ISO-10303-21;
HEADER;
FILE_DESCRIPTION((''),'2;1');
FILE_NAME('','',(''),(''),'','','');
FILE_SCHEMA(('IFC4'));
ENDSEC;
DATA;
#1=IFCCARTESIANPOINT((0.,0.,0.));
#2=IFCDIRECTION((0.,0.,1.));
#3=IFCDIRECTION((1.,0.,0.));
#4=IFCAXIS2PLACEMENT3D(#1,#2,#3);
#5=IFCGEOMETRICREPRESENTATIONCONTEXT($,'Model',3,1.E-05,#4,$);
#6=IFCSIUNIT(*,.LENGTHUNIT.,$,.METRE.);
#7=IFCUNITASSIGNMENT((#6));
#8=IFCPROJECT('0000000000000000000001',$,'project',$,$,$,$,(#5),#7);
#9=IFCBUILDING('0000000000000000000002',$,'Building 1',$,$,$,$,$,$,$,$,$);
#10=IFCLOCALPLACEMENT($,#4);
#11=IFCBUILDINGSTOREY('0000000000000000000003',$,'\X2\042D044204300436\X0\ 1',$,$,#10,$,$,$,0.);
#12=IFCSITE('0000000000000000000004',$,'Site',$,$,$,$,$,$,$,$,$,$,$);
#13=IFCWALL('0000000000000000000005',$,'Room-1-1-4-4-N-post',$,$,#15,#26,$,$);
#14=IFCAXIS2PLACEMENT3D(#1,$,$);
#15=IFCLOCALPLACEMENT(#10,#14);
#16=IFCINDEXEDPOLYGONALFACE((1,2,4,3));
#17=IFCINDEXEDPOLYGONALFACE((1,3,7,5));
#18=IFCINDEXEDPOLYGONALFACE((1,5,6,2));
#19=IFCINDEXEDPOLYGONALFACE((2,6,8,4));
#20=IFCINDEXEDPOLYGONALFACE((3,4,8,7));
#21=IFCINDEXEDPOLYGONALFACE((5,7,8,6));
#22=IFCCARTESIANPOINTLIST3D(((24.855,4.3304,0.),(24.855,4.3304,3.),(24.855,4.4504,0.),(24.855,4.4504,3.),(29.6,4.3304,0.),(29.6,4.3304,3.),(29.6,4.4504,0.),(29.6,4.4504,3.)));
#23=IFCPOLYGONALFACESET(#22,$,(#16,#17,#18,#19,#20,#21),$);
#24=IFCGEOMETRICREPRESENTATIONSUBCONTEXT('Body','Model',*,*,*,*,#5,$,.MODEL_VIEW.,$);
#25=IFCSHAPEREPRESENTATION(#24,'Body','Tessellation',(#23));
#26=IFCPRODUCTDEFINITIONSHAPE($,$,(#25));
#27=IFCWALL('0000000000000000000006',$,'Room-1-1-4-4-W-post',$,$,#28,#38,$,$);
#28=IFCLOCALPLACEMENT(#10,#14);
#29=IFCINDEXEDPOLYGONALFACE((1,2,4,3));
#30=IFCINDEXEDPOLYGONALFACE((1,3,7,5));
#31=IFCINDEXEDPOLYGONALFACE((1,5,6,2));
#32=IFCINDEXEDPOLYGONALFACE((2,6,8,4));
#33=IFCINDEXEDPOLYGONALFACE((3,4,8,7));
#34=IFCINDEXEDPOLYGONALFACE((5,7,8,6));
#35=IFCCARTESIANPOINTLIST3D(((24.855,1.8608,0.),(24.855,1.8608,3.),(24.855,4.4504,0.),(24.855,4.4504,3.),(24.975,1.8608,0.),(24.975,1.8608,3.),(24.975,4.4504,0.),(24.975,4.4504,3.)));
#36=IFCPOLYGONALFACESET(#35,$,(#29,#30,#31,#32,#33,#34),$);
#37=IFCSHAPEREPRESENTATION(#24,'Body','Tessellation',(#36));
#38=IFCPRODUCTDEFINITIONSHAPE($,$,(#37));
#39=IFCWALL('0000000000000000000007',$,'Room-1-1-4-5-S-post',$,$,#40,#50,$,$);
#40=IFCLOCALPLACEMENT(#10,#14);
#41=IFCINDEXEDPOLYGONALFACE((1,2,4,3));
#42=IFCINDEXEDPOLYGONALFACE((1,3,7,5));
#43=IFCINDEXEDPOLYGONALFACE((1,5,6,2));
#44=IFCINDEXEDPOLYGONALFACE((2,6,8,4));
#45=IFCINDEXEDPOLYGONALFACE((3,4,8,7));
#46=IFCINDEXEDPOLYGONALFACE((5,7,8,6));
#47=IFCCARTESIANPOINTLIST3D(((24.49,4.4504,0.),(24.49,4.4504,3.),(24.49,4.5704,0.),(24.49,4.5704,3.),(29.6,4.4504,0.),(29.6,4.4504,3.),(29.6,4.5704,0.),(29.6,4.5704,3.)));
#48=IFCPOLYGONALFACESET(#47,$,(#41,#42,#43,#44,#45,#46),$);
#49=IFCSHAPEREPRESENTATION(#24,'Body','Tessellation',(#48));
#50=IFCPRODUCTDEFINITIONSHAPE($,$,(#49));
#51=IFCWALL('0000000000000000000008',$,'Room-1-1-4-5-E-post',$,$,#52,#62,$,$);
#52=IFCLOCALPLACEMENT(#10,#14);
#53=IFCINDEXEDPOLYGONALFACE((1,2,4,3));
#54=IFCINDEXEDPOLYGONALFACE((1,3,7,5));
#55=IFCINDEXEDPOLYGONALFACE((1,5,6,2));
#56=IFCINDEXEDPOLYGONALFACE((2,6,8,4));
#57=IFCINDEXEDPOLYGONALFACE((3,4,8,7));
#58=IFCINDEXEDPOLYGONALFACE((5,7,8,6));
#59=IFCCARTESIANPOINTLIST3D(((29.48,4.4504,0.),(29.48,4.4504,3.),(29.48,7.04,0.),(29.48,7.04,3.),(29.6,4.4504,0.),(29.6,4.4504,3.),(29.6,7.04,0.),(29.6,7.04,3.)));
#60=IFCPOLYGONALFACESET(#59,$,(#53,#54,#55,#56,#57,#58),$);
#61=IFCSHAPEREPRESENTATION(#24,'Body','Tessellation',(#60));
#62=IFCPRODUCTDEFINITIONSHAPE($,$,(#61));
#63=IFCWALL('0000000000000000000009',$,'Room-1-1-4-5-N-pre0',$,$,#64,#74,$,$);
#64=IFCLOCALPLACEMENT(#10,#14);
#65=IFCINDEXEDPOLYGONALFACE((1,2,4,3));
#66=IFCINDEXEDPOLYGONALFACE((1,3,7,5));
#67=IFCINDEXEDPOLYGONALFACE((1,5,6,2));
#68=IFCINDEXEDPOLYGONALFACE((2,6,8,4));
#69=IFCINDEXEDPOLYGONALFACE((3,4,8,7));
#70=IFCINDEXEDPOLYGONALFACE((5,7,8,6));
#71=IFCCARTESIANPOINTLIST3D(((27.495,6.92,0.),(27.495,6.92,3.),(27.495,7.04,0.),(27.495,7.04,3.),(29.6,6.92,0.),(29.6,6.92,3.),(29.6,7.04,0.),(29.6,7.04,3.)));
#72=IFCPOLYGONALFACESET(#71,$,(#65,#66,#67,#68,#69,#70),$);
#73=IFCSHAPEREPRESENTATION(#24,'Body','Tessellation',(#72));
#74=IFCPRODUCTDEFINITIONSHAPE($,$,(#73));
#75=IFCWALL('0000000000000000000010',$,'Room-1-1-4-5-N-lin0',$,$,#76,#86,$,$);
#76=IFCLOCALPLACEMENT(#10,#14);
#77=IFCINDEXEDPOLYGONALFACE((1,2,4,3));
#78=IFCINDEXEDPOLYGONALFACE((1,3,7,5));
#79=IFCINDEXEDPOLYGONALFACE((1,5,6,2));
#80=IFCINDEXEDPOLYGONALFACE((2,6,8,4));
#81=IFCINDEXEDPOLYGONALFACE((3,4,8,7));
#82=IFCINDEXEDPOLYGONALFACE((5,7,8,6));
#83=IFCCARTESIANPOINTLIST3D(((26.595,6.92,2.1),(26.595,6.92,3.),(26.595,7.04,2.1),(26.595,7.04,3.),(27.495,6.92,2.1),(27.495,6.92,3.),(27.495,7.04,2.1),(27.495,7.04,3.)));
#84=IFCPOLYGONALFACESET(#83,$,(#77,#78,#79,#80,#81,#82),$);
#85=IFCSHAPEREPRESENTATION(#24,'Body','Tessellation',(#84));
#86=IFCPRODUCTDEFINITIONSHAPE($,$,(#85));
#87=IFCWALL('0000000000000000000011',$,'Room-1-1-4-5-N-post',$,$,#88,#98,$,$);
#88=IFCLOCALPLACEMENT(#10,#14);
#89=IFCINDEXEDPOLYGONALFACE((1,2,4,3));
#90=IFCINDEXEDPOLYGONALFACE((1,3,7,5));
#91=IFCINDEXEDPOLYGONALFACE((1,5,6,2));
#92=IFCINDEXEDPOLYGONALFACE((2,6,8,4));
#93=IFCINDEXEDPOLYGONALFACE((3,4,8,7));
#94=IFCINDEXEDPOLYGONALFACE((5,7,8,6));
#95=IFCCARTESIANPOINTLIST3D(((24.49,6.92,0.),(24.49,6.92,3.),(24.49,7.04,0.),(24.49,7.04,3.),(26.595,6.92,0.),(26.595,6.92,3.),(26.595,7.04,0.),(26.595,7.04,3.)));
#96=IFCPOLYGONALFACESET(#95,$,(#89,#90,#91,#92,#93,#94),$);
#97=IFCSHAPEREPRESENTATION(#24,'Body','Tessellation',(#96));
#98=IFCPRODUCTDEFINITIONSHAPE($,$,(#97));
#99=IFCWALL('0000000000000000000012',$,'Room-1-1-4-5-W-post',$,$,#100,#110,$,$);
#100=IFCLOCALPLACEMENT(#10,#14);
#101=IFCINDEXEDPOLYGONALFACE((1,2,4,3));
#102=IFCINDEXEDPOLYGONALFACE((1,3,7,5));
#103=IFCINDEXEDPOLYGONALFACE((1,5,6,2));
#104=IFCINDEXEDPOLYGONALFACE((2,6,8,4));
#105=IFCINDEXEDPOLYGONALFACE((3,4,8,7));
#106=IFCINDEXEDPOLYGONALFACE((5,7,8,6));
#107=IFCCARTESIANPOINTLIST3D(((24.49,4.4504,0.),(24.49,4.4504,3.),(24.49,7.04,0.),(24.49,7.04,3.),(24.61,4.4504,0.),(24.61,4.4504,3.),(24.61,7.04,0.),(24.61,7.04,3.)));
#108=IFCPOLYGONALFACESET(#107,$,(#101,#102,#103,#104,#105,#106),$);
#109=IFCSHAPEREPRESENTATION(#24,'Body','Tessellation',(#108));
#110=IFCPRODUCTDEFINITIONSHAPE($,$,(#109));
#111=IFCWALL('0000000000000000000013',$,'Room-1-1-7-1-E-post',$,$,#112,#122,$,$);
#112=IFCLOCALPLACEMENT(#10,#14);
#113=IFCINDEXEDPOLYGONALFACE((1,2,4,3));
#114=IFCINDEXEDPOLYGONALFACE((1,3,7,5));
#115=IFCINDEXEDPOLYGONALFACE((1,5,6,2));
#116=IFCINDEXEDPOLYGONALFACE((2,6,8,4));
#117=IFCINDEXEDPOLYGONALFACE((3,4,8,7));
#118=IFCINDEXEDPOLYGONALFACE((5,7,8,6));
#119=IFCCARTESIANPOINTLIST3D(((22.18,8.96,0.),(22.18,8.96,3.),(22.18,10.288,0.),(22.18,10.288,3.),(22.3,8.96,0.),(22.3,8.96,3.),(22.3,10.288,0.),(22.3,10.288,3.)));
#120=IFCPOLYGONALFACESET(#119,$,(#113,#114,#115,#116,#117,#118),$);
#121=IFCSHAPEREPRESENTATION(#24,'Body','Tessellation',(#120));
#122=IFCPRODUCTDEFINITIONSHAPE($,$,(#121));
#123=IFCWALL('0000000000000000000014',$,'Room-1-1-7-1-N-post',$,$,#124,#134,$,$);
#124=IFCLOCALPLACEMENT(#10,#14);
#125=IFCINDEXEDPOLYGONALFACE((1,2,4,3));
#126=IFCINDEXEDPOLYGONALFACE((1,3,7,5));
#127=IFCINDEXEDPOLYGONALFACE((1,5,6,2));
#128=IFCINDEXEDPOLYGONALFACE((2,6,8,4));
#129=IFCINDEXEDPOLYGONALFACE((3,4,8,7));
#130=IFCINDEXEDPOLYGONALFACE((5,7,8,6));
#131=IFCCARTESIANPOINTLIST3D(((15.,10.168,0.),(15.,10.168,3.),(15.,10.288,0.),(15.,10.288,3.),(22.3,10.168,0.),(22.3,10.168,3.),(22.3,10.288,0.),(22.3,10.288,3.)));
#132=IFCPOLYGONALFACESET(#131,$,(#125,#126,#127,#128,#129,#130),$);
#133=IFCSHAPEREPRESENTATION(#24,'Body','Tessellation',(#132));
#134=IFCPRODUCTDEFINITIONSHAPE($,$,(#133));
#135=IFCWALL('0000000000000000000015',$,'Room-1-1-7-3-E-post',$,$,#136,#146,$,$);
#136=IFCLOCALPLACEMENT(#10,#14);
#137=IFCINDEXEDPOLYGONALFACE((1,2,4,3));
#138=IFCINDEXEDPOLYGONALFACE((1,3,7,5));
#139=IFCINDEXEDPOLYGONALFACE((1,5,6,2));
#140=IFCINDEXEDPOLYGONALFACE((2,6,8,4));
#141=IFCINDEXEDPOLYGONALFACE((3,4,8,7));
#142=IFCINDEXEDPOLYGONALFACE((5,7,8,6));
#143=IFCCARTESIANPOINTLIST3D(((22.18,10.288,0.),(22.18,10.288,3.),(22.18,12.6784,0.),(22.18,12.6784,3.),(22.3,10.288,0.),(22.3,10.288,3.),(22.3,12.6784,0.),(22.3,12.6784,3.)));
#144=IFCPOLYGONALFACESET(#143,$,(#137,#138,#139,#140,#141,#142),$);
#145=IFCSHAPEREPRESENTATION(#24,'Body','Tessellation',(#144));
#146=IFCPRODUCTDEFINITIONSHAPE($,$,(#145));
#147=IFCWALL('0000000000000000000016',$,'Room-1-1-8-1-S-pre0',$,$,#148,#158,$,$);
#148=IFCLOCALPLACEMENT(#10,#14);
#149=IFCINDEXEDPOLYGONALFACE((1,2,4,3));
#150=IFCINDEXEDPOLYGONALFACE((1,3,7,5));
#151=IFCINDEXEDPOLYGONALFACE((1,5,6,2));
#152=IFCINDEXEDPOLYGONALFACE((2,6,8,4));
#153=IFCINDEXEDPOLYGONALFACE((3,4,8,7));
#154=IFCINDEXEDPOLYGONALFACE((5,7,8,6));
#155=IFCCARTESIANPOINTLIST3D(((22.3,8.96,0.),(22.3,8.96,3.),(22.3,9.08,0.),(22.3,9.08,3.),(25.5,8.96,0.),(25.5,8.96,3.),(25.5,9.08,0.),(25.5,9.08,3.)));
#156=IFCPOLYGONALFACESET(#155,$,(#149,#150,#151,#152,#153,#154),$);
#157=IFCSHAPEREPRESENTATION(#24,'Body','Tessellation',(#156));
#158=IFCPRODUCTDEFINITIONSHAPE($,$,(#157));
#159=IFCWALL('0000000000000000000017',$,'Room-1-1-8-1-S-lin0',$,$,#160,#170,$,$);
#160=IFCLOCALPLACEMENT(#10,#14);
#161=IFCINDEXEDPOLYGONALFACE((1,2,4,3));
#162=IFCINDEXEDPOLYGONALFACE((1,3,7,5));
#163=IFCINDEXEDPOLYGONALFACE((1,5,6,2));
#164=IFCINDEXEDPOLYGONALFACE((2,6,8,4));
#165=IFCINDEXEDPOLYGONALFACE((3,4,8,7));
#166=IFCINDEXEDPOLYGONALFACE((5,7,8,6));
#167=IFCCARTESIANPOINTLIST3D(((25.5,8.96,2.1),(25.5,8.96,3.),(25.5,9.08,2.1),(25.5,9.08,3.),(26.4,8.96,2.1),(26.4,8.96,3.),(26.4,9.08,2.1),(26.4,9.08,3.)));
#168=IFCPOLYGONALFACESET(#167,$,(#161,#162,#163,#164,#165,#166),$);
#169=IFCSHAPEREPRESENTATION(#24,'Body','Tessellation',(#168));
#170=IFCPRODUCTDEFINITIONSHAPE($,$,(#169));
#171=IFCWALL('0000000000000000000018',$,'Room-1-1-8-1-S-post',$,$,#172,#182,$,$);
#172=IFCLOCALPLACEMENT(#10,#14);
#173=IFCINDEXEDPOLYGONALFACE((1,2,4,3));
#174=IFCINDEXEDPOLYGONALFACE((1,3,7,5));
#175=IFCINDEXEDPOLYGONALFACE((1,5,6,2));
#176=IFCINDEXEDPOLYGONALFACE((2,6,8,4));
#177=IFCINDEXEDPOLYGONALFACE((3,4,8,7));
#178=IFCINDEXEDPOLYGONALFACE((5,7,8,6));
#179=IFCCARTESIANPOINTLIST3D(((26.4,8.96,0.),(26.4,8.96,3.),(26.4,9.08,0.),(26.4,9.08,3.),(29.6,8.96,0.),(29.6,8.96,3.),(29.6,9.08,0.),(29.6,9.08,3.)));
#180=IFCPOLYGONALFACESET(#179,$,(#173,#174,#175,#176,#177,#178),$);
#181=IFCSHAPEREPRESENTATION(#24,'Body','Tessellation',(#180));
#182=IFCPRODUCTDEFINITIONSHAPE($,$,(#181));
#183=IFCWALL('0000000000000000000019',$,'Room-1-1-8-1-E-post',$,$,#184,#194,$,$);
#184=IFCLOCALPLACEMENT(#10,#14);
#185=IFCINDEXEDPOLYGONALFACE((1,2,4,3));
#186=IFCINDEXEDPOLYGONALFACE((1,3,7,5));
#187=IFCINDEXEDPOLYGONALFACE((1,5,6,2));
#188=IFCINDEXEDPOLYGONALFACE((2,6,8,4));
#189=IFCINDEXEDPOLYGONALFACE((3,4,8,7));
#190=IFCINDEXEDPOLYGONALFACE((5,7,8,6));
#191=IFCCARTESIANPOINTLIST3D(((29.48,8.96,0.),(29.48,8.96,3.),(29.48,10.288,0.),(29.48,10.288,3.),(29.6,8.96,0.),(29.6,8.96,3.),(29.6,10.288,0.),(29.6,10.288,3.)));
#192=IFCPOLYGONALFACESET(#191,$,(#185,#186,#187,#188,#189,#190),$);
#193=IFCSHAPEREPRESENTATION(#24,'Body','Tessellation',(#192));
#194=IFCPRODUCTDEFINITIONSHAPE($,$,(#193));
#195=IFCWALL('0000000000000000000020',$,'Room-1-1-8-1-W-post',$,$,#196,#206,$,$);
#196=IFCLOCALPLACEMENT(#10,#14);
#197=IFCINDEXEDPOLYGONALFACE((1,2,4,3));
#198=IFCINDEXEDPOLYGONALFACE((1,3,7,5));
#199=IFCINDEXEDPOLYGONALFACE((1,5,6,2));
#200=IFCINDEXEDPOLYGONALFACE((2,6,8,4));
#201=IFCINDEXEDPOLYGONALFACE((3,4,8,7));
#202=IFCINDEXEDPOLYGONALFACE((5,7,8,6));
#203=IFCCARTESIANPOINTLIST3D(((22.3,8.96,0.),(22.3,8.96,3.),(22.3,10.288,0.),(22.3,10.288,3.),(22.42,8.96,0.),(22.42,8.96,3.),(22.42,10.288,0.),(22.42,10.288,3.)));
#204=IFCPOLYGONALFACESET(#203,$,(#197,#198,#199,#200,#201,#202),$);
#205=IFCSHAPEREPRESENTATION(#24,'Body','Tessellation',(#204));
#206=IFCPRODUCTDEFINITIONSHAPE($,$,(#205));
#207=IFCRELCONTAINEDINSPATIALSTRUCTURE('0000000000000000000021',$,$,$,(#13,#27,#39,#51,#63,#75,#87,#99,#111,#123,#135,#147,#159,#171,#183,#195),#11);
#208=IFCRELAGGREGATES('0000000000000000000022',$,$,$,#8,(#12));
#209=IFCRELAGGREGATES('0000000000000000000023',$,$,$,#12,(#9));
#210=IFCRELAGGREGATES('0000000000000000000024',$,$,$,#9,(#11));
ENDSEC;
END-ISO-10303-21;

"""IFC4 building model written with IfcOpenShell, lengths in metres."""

from ifc_helpers import new_model, si_unit, frame, origin_with_axes, place, context, subcontext, project, spatial, indexed_curve, outline, extrude, element, save


model = new_model("IFC4")

# Units and contexts
model_context = context("Model", 3, precision=1e-05, world=origin_with_axes())
body_context = subcontext(model_context, "Body", "Model", "MODEL_VIEW")
ifc_project = project(units=[si_unit("LENGTHUNIT", "METRE")], contexts=[model_context])

# Site, building, storey
site = spatial("IfcSite", under=ifc_project, Name="Site")
building = spatial("IfcBuilding", under=site, Name="Building 1")
storey_placement = place(None, origin_with_axes())
storey = spatial("IfcBuildingStorey", under=building, at=storey_placement, Name="Этаж 1", Elevation=0.0)

# Walls
wall_1_placement = place(storey_placement, frame((29.6, 4.4504, 0.0), z_axis=(0.0, 0.0, 1.0), x_axis=(-1.0, 0.0, 0.0)))
element("IfcWall", 1, at=wall_1_placement, inside=storey, Name="Room-1-1-4-4-N-post", context=body_context, shape_type="SweptSolid", body=[
    extrude(outline(indexed_curve([(0.0, 0.0), (0.0, 0.12), (4.745, 0.12), (4.745, 0.0), (0.0, 0.0)], self_intersect=False)), origin_with_axes(), (0.0, 0.0, 1.0), 3.0),
])
wall_2_placement = place(storey_placement, frame((24.855, 4.4504, 0.0), z_axis=(0.0, 0.0, 1.0), x_axis=(0.0, -1.0, 0.0)))
element("IfcWall", 2, at=wall_2_placement, inside=storey, Name="Room-1-1-4-4-W-post", context=body_context, shape_type="SweptSolid", body=[
    extrude(outline(indexed_curve([(0.0, 0.0), (0.0, 0.12), (2.5896, 0.12), (2.5896, 0.0), (0.0, 0.0)], self_intersect=False)), origin_with_axes(), (0.0, 0.0, 1.0), 3.0),
])
wall_3_placement = place(storey_placement, frame((24.49, 4.4504, 0.0), z_axis=(0.0, 0.0, 1.0), x_axis=(1.0, 0.0, 0.0)))
element("IfcWall", 3, at=wall_3_placement, inside=storey, Name="Room-1-1-4-5-S-post", context=body_context, shape_type="SweptSolid", body=[
    extrude(outline(indexed_curve([(0.0, 0.0), (0.0, 0.12), (5.11, 0.12), (5.11, 0.0), (0.0, 0.0)], self_intersect=False)), origin_with_axes(), (0.0, 0.0, 1.0), 3.0),
])
wall_4_placement = place(storey_placement, frame((29.6, 4.4504, 0.0), z_axis=(0.0, 0.0, 1.0), x_axis=(0.0, 1.0, 0.0)))
element("IfcWall", 4, at=wall_4_placement, inside=storey, Name="Room-1-1-4-5-E-post", context=body_context, shape_type="SweptSolid", body=[
    extrude(outline(indexed_curve([(0.0, 0.0), (0.0, 0.12), (2.5896, 0.12), (2.5896, 0.0), (0.0, 0.0)], self_intersect=False)), origin_with_axes(), (0.0, 0.0, 1.0), 3.0),
])
wall_5_placement = place(storey_placement, frame((29.6, 7.04, 0.0), z_axis=(0.0, 0.0, 1.0), x_axis=(-1.0, 0.0, 0.0)))
element("IfcWall", 5, at=wall_5_placement, inside=storey, Name="Room-1-1-4-5-N-pre0", context=body_context, shape_type="SweptSolid", body=[
    extrude(outline(indexed_curve([(0.0, 0.0), (0.0, 0.12), (2.105, 0.12), (2.105, 0.0), (0.0, 0.0)], self_intersect=False)), origin_with_axes(), (0.0, 0.0, 1.0), 3.0),
])
wall_6_placement = place(storey_placement, frame((27.495, 7.04, 2.1), z_axis=(0.0, 0.0, 1.0), x_axis=(-1.0, 0.0, 0.0)))
element("IfcWall", 6, at=wall_6_placement, inside=storey, Name="Room-1-1-4-5-N-lin0", context=body_context, shape_type="SweptSolid", body=[
    extrude(outline(indexed_curve([(0.0, 0.0), (0.0, 0.12), (0.9, 0.12), (0.9, 0.0), (0.0, 0.0)], self_intersect=False)), origin_with_axes(), (0.0, 0.0, 1.0), 0.9),
])
wall_7_placement = place(storey_placement, frame((26.595, 7.04, 0.0), z_axis=(0.0, 0.0, 1.0), x_axis=(-1.0, 0.0, 0.0)))
element("IfcWall", 7, at=wall_7_placement, inside=storey, Name="Room-1-1-4-5-N-post", context=body_context, shape_type="SweptSolid", body=[
    extrude(outline(indexed_curve([(0.0, 0.0), (0.0, 0.12), (2.105, 0.12), (2.105, 0.0), (0.0, 0.0)], self_intersect=False)), origin_with_axes(), (0.0, 0.0, 1.0), 3.0),
])
wall_8_placement = place(storey_placement, frame((24.49, 7.04, 0.0), z_axis=(0.0, 0.0, 1.0), x_axis=(0.0, -1.0, 0.0)))
element("IfcWall", 8, at=wall_8_placement, inside=storey, Name="Room-1-1-4-5-W-post", context=body_context, shape_type="SweptSolid", body=[
    extrude(outline(indexed_curve([(0.0, 0.0), (0.0, 0.12), (2.5896, 0.12), (2.5896, 0.0), (0.0, 0.0)], self_intersect=False)), origin_with_axes(), (0.0, 0.0, 1.0), 3.0),
])
wall_9_placement = place(storey_placement, frame((22.3, 8.96, 0.0), z_axis=(0.0, 0.0, 1.0), x_axis=(0.0, 1.0, 0.0)))
element("IfcWall", 9, at=wall_9_placement, inside=storey, Name="Room-1-1-7-1-E-post", context=body_context, shape_type="SweptSolid", body=[
    extrude(outline(indexed_curve([(0.0, 0.0), (0.0, 0.12), (1.328, 0.12), (1.328, 0.0), (0.0, 0.0)], self_intersect=False)), origin_with_axes(), (0.0, 0.0, 1.0), 3.0),
])
wall_10_placement = place(storey_placement, frame((22.3, 10.288, 0.0), z_axis=(0.0, 0.0, 1.0), x_axis=(-1.0, 0.0, 0.0)))
element("IfcWall", 10, at=wall_10_placement, inside=storey, Name="Room-1-1-7-1-N-post", context=body_context, shape_type="SweptSolid", body=[
    extrude(outline(indexed_curve([(0.0, 0.0), (0.0, 0.12), (7.3, 0.12), (7.3, 0.0), (0.0, 0.0)], self_intersect=False)), origin_with_axes(), (0.0, 0.0, 1.0), 3.0),
])
wall_11_placement = place(storey_placement, frame((22.3, 10.288, 0.0), z_axis=(0.0, 0.0, 1.0), x_axis=(0.0, 1.0, 0.0)))
element("IfcWall", 11, at=wall_11_placement, inside=storey, Name="Room-1-1-7-3-E-post", context=body_context, shape_type="SweptSolid", body=[
    extrude(outline(indexed_curve([(0.0, 0.0), (0.0, 0.12), (2.3904, 0.12), (2.3904, 0.0), (0.0, 0.0)], self_intersect=False)), origin_with_axes(), (0.0, 0.0, 1.0), 3.0),
])
wall_12_placement = place(storey_placement, frame((22.3, 8.96, 0.0), z_axis=(0.0, 0.0, 1.0), x_axis=(1.0, 0.0, 0.0)))
element("IfcWall", 12, at=wall_12_placement, inside=storey, Name="Room-1-1-8-1-S-pre0", context=body_context, shape_type="SweptSolid", body=[
    extrude(outline(indexed_curve([(0.0, 0.0), (0.0, 0.12), (3.2, 0.12), (3.2, 0.0), (0.0, 0.0)], self_intersect=False)), origin_with_axes(), (0.0, 0.0, 1.0), 3.0),
])
wall_13_placement = place(storey_placement, frame((25.5, 8.96, 2.1), z_axis=(0.0, 0.0, 1.0), x_axis=(1.0, 0.0, 0.0)))
element("IfcWall", 13, at=wall_13_placement, inside=storey, Name="Room-1-1-8-1-S-lin0", context=body_context, shape_type="SweptSolid", body=[
    extrude(outline(indexed_curve([(0.0, 0.0), (0.0, 0.12), (0.9, 0.12), (0.9, 0.0), (0.0, 0.0)], self_intersect=False)), origin_with_axes(), (0.0, 0.0, 1.0), 0.9),
])
wall_14_placement = place(storey_placement, frame((26.4, 8.96, 0.0), z_axis=(0.0, 0.0, 1.0), x_axis=(1.0, 0.0, 0.0)))
element("IfcWall", 14, at=wall_14_placement, inside=storey, Name="Room-1-1-8-1-S-post", context=body_context, shape_type="SweptSolid", body=[
    extrude(outline(indexed_curve([(0.0, 0.0), (0.0, 0.12), (3.2, 0.12), (3.2, 0.0), (0.0, 0.0)], self_intersect=False)), origin_with_axes(), (0.0, 0.0, 1.0), 3.0),
])
for number, where, z_axis, x_axis, name in (
    (15, (29.6, 8.96, 0.0), (0.0, 0.0, 1.0), (0.0, 1.0, 0.0), "Room-1-1-8-1-E-post"),
    (16, (22.3, 10.288, 0.0), (0.0, 0.0, 1.0), (0.0, -1.0, 0.0), "Room-1-1-8-1-W-post"),
):
    element("IfcWall", number, at=place(storey_placement, frame(where, z_axis=z_axis, x_axis=x_axis)), inside=storey, Name=name, context=body_context, shape_type="SweptSolid", body=[
        extrude(outline(indexed_curve([(0.0, 0.0), (0.0, 0.12), (1.328, 0.12), (1.328, 0.0), (0.0, 0.0)], self_intersect=False)), origin_with_axes(), (0.0, 0.0, 1.0), 3.0),
    ])

save(model, "model.ifc")
